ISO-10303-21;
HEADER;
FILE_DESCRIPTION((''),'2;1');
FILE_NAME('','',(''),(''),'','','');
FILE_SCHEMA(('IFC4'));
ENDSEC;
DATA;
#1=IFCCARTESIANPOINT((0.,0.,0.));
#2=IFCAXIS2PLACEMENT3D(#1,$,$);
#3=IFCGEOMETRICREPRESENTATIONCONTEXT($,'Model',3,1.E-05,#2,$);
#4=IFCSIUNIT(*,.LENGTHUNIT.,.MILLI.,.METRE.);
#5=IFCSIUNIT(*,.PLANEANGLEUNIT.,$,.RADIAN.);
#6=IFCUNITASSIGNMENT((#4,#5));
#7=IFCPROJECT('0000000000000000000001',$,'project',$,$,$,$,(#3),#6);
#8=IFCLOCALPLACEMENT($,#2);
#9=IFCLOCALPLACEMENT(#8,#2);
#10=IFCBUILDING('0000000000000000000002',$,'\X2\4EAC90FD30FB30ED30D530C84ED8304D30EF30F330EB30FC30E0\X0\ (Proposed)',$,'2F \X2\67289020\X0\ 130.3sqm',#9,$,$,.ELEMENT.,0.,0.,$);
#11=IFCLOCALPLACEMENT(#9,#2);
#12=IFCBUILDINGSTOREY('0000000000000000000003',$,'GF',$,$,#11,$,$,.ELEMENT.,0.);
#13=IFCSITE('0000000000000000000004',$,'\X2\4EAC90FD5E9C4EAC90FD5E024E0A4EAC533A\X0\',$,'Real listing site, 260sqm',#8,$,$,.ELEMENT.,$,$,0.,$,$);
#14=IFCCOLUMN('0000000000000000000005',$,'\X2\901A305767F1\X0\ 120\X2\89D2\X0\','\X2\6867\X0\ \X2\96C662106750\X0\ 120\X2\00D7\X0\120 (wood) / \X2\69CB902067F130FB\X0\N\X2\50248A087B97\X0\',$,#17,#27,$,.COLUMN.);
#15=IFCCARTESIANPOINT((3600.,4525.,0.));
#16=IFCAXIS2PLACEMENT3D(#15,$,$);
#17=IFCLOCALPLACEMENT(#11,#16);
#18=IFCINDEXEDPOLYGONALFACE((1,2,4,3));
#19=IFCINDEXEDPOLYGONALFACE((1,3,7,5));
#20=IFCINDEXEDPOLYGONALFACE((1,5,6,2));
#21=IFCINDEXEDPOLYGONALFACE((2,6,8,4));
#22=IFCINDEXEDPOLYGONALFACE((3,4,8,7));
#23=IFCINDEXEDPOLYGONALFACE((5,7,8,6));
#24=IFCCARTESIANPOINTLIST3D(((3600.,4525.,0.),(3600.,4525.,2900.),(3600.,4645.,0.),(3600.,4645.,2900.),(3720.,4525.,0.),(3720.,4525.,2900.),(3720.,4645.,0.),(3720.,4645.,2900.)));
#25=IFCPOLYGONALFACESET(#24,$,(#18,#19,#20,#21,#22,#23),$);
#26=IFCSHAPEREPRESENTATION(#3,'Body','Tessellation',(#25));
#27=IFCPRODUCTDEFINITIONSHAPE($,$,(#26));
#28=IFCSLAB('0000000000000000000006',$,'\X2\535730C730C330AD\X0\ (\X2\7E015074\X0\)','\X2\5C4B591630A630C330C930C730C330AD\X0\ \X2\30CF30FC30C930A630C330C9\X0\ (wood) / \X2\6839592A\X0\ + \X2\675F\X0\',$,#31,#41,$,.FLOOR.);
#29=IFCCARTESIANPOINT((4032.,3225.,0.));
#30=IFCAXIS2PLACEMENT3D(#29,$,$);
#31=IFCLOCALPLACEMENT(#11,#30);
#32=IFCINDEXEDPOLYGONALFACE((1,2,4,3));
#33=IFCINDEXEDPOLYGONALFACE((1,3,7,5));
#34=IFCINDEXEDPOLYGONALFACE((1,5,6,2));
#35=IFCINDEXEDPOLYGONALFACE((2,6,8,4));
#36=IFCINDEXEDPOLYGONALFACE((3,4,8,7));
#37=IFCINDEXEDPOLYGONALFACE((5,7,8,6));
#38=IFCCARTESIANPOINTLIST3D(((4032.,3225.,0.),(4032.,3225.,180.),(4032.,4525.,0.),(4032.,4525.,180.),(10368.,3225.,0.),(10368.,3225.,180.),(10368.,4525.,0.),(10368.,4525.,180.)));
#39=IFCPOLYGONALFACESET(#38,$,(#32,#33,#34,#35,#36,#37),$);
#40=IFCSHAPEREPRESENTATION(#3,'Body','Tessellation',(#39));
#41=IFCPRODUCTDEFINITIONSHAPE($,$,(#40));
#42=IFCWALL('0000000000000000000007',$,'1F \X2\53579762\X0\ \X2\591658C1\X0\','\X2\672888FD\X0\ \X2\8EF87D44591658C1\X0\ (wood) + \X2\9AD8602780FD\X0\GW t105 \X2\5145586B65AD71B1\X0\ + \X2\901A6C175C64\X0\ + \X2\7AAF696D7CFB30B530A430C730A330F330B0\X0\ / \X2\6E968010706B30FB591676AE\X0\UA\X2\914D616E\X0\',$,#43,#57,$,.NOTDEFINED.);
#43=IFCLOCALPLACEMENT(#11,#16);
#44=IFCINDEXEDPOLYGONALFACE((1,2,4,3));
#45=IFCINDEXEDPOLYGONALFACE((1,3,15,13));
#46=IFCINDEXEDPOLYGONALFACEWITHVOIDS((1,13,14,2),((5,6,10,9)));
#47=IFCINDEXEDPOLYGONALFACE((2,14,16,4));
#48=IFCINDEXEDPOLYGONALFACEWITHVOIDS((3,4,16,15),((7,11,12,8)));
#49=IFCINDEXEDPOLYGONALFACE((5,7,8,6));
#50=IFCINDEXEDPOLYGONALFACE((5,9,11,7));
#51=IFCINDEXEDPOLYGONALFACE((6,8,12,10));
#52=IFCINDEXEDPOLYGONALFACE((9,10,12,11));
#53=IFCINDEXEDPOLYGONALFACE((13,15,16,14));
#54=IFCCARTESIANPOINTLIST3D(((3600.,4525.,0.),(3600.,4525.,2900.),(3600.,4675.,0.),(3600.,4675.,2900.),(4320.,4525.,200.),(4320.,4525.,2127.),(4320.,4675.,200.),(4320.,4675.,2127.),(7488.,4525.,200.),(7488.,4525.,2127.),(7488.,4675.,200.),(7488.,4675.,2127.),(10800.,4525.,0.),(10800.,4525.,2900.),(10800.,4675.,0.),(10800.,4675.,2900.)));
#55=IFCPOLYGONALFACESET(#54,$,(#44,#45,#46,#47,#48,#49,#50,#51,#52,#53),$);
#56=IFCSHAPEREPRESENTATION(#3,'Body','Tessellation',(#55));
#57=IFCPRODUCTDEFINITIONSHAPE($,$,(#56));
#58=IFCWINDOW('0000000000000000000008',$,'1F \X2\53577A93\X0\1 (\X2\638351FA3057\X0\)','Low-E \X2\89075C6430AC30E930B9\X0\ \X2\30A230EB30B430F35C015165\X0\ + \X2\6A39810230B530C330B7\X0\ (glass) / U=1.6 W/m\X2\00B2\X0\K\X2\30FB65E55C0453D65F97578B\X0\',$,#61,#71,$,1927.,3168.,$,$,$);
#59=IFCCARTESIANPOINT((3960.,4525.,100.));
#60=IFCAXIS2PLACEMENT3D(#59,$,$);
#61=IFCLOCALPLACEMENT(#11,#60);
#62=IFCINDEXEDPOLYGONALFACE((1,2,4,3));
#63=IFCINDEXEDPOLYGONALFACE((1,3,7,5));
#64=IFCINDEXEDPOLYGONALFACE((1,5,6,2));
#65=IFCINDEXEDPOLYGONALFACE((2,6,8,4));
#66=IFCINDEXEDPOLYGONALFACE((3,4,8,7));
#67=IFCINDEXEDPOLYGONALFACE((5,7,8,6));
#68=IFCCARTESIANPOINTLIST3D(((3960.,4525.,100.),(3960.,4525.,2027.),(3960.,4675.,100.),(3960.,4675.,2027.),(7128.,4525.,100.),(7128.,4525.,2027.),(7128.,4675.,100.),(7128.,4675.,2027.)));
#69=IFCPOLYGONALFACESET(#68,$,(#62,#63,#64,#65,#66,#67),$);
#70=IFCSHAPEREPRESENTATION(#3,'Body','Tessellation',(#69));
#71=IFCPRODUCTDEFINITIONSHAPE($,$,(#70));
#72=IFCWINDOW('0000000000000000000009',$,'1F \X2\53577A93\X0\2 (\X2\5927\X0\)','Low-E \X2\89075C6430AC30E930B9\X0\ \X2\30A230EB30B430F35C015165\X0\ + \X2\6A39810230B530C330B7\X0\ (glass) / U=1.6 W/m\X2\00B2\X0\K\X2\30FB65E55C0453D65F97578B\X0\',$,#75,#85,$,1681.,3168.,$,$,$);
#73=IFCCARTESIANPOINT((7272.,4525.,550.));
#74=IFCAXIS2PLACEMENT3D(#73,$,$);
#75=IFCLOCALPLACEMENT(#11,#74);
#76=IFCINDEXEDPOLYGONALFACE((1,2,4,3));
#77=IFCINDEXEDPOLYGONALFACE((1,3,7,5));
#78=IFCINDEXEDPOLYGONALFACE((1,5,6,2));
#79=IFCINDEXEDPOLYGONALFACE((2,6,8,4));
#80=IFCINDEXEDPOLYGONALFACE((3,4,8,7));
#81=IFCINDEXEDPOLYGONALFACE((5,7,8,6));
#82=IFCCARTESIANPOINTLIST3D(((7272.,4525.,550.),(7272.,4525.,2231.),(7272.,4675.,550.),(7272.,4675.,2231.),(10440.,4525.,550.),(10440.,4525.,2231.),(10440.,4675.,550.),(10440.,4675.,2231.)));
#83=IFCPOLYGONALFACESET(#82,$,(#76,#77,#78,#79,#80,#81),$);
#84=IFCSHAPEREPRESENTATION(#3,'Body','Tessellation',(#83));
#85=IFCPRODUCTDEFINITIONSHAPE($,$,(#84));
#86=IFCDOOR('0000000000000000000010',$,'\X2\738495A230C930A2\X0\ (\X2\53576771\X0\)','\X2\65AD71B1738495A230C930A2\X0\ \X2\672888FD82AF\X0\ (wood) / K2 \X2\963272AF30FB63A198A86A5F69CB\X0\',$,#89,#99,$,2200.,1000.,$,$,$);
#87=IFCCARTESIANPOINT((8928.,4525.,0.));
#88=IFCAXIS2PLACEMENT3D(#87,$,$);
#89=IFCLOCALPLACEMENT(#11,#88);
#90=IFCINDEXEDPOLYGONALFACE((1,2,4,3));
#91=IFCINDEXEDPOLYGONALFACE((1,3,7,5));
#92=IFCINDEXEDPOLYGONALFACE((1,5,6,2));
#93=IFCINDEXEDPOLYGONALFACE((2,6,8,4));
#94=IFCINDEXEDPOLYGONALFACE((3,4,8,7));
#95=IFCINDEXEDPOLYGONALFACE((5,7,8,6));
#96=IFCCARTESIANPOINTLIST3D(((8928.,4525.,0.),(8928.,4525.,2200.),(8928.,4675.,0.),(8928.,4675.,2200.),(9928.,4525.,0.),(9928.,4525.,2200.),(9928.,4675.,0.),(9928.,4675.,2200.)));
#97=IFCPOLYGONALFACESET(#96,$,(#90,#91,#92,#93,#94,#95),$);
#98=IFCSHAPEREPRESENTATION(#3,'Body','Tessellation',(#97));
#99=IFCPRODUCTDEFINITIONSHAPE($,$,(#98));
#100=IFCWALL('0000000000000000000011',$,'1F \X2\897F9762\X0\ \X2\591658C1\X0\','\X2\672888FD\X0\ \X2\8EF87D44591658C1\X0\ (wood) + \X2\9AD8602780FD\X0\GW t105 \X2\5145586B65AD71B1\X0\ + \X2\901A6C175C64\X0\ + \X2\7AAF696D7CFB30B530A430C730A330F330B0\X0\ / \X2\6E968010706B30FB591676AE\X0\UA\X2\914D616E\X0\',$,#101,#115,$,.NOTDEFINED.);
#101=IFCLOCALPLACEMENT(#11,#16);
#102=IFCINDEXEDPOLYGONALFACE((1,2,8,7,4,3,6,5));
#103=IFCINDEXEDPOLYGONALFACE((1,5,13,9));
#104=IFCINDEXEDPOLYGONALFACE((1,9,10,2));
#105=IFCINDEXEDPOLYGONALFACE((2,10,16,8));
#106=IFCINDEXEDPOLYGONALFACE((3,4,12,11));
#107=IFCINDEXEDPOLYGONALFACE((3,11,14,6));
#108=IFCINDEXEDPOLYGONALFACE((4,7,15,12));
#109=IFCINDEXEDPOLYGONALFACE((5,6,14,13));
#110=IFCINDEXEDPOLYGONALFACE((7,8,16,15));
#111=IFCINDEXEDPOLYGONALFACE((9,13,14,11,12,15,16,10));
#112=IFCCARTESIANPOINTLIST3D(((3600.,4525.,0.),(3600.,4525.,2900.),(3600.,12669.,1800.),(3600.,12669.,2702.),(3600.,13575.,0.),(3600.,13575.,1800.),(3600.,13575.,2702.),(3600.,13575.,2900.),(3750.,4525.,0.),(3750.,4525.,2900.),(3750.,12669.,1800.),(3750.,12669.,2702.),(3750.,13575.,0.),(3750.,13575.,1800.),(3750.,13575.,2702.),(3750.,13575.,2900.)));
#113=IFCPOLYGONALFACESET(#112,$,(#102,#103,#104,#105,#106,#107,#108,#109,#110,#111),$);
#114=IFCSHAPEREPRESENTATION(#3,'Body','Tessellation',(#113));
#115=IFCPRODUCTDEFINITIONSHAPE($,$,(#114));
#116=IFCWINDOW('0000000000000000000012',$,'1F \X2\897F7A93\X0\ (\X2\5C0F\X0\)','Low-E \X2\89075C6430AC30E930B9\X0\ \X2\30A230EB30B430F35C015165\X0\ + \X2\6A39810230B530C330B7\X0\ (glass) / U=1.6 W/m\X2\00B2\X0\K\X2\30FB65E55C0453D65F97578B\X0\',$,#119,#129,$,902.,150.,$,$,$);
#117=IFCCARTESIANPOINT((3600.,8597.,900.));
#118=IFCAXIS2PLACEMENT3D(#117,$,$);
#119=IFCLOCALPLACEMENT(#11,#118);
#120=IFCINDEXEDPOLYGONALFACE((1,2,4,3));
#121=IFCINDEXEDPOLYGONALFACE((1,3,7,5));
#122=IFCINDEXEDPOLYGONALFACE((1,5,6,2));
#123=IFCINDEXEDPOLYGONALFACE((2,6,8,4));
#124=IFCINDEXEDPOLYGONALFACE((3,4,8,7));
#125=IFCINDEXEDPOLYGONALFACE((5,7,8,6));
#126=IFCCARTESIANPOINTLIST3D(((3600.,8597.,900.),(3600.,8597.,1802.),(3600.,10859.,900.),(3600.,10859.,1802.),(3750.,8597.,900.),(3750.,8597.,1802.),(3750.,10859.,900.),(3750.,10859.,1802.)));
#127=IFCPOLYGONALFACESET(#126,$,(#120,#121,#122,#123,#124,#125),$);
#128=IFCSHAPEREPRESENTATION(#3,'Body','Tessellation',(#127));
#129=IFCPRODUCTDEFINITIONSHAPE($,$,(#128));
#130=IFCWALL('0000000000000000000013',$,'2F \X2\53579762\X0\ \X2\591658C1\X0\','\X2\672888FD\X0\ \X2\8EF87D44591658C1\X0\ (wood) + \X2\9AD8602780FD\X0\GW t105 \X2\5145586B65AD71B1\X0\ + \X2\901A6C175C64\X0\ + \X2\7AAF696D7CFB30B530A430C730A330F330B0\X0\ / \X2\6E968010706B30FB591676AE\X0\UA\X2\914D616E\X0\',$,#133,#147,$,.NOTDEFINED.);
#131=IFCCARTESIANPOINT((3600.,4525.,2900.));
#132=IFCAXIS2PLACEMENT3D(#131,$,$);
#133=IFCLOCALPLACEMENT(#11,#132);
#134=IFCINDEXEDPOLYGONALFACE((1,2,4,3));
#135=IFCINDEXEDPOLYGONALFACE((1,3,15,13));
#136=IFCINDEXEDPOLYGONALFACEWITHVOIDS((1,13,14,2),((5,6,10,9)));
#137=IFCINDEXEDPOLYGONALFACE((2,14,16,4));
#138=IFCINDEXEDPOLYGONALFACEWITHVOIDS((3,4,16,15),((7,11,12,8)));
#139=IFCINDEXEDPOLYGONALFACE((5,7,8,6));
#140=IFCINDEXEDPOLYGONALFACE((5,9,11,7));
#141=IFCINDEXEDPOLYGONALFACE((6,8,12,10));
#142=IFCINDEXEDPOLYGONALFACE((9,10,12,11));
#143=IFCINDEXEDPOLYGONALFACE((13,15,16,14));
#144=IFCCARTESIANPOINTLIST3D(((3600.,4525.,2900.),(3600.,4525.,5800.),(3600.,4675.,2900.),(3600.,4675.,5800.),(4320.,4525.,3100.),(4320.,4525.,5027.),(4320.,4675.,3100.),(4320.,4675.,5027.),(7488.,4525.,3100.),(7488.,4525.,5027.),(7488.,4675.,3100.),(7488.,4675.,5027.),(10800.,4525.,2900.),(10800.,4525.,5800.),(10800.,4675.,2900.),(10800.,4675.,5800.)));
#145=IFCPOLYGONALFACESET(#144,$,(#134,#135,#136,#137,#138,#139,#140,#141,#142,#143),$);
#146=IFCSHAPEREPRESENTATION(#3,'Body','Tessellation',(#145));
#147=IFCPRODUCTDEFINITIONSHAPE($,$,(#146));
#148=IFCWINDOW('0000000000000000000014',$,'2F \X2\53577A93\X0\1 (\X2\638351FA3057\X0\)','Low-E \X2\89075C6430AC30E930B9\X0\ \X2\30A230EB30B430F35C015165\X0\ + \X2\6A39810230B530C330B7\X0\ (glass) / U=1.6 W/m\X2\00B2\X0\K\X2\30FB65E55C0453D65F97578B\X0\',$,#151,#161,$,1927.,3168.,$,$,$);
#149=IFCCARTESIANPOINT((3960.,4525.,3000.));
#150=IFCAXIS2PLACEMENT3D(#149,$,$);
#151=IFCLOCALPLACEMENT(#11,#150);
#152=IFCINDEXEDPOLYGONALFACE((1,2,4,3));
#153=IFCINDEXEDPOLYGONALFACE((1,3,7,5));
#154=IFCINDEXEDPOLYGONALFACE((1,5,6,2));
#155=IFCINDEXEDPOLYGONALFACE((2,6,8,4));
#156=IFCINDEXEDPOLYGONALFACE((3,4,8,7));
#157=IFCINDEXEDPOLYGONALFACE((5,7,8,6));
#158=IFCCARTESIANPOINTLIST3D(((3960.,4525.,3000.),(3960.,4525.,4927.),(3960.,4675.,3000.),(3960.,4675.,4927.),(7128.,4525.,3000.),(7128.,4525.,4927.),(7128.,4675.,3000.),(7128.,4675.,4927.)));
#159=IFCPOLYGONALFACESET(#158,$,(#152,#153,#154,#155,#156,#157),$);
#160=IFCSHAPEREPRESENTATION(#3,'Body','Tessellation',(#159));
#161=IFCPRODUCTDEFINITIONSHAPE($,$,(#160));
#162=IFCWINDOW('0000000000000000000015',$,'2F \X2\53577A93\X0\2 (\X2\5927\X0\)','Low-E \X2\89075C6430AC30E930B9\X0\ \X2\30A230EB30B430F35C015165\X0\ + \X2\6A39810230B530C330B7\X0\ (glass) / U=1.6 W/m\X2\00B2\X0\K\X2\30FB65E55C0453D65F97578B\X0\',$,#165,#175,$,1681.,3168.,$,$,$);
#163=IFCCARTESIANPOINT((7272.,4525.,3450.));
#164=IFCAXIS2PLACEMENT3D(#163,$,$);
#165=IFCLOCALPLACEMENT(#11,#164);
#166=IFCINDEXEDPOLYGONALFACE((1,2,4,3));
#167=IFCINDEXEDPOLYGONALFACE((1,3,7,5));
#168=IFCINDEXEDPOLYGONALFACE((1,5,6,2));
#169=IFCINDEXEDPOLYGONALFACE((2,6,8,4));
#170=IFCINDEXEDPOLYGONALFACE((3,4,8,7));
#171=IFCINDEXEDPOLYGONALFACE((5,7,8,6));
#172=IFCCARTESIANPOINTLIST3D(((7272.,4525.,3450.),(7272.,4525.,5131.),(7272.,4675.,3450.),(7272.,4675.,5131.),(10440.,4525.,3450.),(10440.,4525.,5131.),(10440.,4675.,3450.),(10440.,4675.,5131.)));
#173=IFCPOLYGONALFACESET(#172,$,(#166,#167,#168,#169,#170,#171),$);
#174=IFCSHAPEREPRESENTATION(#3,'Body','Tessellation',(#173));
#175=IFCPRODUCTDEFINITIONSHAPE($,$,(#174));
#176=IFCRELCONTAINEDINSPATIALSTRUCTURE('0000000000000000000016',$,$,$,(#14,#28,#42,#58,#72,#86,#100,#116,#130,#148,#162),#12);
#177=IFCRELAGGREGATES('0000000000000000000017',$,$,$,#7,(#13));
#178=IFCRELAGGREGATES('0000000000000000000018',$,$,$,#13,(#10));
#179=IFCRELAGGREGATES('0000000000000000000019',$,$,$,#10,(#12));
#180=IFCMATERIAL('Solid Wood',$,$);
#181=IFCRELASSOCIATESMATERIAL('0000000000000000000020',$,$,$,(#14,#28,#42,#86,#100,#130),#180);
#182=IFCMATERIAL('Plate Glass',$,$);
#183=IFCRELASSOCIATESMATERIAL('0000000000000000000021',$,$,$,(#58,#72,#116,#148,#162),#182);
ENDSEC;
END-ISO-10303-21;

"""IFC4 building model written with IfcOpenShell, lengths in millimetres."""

from ifc_helpers import new_model, si_unit, frame, frame_2d, origin, place, context, project, spatial, rectangle, extrude, material, element, fill, save


model = new_model("IFC4")

# Units and contexts
model_context = context("Model", 3, precision=1e-05, world=origin())
ifc_project = project(units=[si_unit("LENGTHUNIT", "METRE", prefix="MILLI"), si_unit("PLANEANGLEUNIT", "RADIAN")], contexts=[model_context])

# Site, building, storey
site_placement = place(None, origin())
site = spatial("IfcSite", under=ifc_project, at=site_placement, Name="京都府京都市上京区", ObjectType="Real listing site, 260sqm", CompositionType="ELEMENT", RefElevation=0.0)
building_placement = place(site_placement, origin())
building = spatial("IfcBuilding", under=site, at=building_placement, Name="京都・ロフト付きワンルーム (Proposed)", ObjectType="2F 木造 130.3sqm", CompositionType="ELEMENT", ElevationOfRefHeight=0.0, ElevationOfTerrain=0.0)
storey_placement = place(building_placement, origin())
storey = spatial("IfcBuildingStorey", under=building, at=storey_placement, Name="GF", CompositionType="ELEMENT", Elevation=0.0)

# Column
ifc_material_1 = material(Name="Solid Wood")
column_placement = place(storey_placement, frame((3600.0, 4525.0, 0.0)))
element("IfcColumn", 1, at=column_placement, inside=storey, material=ifc_material_1, Name="通し柱 120角", Description="桧 集成材 120×120 (wood) / 構造柱・N値計算", PredefinedType="COLUMN", context=model_context, shape_type="SweptSolid", body=[
    extrude(rectangle(XDim=120.0, YDim=120.0, at=frame_2d((60.0, 60.0))), frame((3600.0, 4525.0, 0.0)), (0.0, 0.0, 1.0), 2900.0),
])

# Slab
slab_1_placement = place(storey_placement, frame((4032.0, 3225.0, 0.0)))
element("IfcSlab", 2, at=slab_1_placement, inside=storey, material=ifc_material_1, Name="南デッキ (縁側)", Description="屋外ウッドデッキ ハードウッド (wood) / 根太 + 束", PredefinedType="FLOOR", context=model_context, shape_type="SweptSolid", body=[
    extrude(rectangle(XDim=6336.0, YDim=1300.0, at=frame_2d((3168.0, 650.0))), frame((4032.0, 3225.0, 0.0)), (0.0, 0.0, 1.0), 180.0),
])

# Wall, openings, windows, door
wall_1_placement = place(storey_placement, frame((3600.0, 4525.0, 0.0)))
wall_1 = element("IfcWall", 3, at=wall_1_placement, inside=storey, material=ifc_material_1, Name="1F 南面 外壁", Description="木製 軸組外壁 (wood) + 高性能GW t105 充填断熱 + 通気層 + 窯業系サイディング / 準耐火・外皮UA配慮", PredefinedType="NOTDEFINED", context=model_context, shape_type="SweptSolid", body=[
    extrude(rectangle(XDim=7200.0, YDim=150.0, at=frame_2d((3600.0, 75.0))), frame((3600.0, 4525.0, 0.0)), (0.0, 0.0, 1.0), 2900.0),
])
opening_1_placement = place(storey_placement, frame((3960.0, 4525.0, 100.0)))
opening_1 = element("IfcOpeningElement", 4, at=opening_1_placement, cuts=wall_1, PredefinedType="NOTDEFINED", context=model_context, shape_type="SweptSolid", body=[
    extrude(rectangle(XDim=3168.0, YDim=150.0, at=frame_2d((1584.0, 75.0))), frame((3960.0, 4525.0, 100.0)), (0.0, 0.0, 1.0), 1927.0),
])
opening_2_placement = place(storey_placement, frame((7272.0, 4525.0, 550.0)))
opening_2 = element("IfcOpeningElement", 5, at=opening_2_placement, cuts=wall_1, PredefinedType="NOTDEFINED", context=model_context, shape_type="SweptSolid", body=[
    extrude(rectangle(XDim=3168.0, YDim=150.0, at=frame_2d((1584.0, 75.0))), frame((7272.0, 4525.0, 550.0)), (0.0, 0.0, 1.0), 1681.0),
])
opening_3_placement = place(storey_placement, frame((8928.0, 4525.0, 0.0)))
opening_3 = element("IfcOpeningElement", 6, at=opening_3_placement, cuts=wall_1, PredefinedType="NOTDEFINED", context=model_context, shape_type="SweptSolid", body=[
    extrude(rectangle(XDim=1000.0, YDim=150.0, at=frame_2d((500.0, 75.0))), frame((8928.0, 4525.0, 0.0)), (0.0, 0.0, 1.0), 2200.0),
])
ifc_material_2 = material(Name="Plate Glass")
window_1_placement = place(storey_placement, frame((3960.0, 4525.0, 100.0)))
window_1 = element("IfcWindow", 7, at=window_1_placement, inside=storey, material=ifc_material_2, Name="1F 南窓1 (掃出し)", Description="Low-E 複層ガラス アルゴン封入 + 樹脂サッシ (glass) / U=1.6 W/m²K・日射取得型", OverallHeight=1927.0, OverallWidth=3168.0, context=model_context, shape_type="SweptSolid", body=[
    extrude(rectangle(XDim=3168.0, YDim=150.0, at=frame_2d((1584.0, 75.0))), frame((3960.0, 4525.0, 100.0)), (0.0, 0.0, 1.0), 1927.0),
])
fill(opening_1, window_1)
window_2_placement = place(storey_placement, frame((7272.0, 4525.0, 550.0)))
window_2 = element("IfcWindow", 8, at=window_2_placement, inside=storey, material=ifc_material_2, Name="1F 南窓2 (大)", Description="Low-E 複層ガラス アルゴン封入 + 樹脂サッシ (glass) / U=1.6 W/m²K・日射取得型", OverallHeight=1681.0, OverallWidth=3168.0, context=model_context, shape_type="SweptSolid", body=[
    extrude(rectangle(XDim=3168.0, YDim=150.0, at=frame_2d((1584.0, 75.0))), frame((7272.0, 4525.0, 550.0)), (0.0, 0.0, 1.0), 1681.0),
])
fill(opening_2, window_2)
door_placement = place(storey_placement, frame((8928.0, 4525.0, 0.0)))
door = element("IfcDoor", 9, at=door_placement, inside=storey, material=ifc_material_1, Name="玄関ドア (南東)", Description="断熱玄関ドア 木製芯 (wood) / K2 防犯・採風機構", OverallHeight=2200.0, OverallWidth=1000.0, context=model_context, shape_type="SweptSolid", body=[
    extrude(rectangle(XDim=1000.0, YDim=150.0, at=frame_2d((500.0, 75.0))), frame((8928.0, 4525.0, 0.0)), (0.0, 0.0, 1.0), 2200.0),
])
fill(opening_3, door)

# Wall, opening, window
wall_2_placement = place(storey_placement, frame((3600.0, 4525.0, 0.0)))
wall_2 = element("IfcWall", 10, at=wall_2_placement, inside=storey, material=ifc_material_1, Name="1F 西面 外壁", Description="木製 軸組外壁 (wood) + 高性能GW t105 充填断熱 + 通気層 + 窯業系サイディング / 準耐火・外皮UA配慮", PredefinedType="NOTDEFINED", context=model_context, shape_type="SweptSolid", body=[
    extrude(rectangle(XDim=150.0, YDim=9050.0, at=frame_2d((75.0, 4525.0))), frame((3600.0, 4525.0, 0.0)), (0.0, 0.0, 1.0), 2900.0),
])
opening_4_placement = place(storey_placement, frame((3600.0, 8597.0, 900.0)))
opening_4 = element("IfcOpeningElement", 11, at=opening_4_placement, cuts=wall_2, PredefinedType="NOTDEFINED", context=model_context, shape_type="SweptSolid", body=[
    extrude(rectangle(XDim=150.0, YDim=2262.0, at=frame_2d((75.0, 1131.0))), frame((3600.0, 8597.0, 900.0)), (0.0, 0.0, 1.0), 902.0),
])
window_3_placement = place(storey_placement, frame((3600.0, 8597.0, 900.0)))
window_3 = element("IfcWindow", 12, at=window_3_placement, inside=storey, material=ifc_material_2, Name="1F 西窓 (小)", Description="Low-E 複層ガラス アルゴン封入 + 樹脂サッシ (glass) / U=1.6 W/m²K・日射取得型", OverallHeight=902.0, OverallWidth=150.0, context=model_context, shape_type="SweptSolid", body=[
    extrude(rectangle(XDim=150.0, YDim=2262.0, at=frame_2d((75.0, 1131.0))), frame((3600.0, 8597.0, 900.0)), (0.0, 0.0, 1.0), 902.0),
])
fill(opening_4, window_3)

# Wall, openings, windows
wall_3_placement = place(storey_placement, frame((3600.0, 4525.0, 2900.0)))
wall_3 = element("IfcWall", 13, at=wall_3_placement, inside=storey, material=ifc_material_1, Name="2F 南面 外壁", Description="木製 軸組外壁 (wood) + 高性能GW t105 充填断熱 + 通気層 + 窯業系サイディング / 準耐火・外皮UA配慮", PredefinedType="NOTDEFINED", context=model_context, shape_type="SweptSolid", body=[
    extrude(rectangle(XDim=7200.0, YDim=150.0, at=frame_2d((3600.0, 75.0))), frame((3600.0, 4525.0, 2900.0)), (0.0, 0.0, 1.0), 2900.0),
])
opening_5_placement = place(storey_placement, frame((3960.0, 4525.0, 3000.0)))
opening_5 = element("IfcOpeningElement", 14, at=opening_5_placement, cuts=wall_3, PredefinedType="NOTDEFINED", context=model_context, shape_type="SweptSolid", body=[
    extrude(rectangle(XDim=3168.0, YDim=150.0, at=frame_2d((1584.0, 75.0))), frame((3960.0, 4525.0, 3000.0)), (0.0, 0.0, 1.0), 1927.0),
])
opening_6_placement = place(storey_placement, frame((7272.0, 4525.0, 3450.0)))
opening_6 = element("IfcOpeningElement", 15, at=opening_6_placement, cuts=wall_3, PredefinedType="NOTDEFINED", context=model_context, shape_type="SweptSolid", body=[
    extrude(rectangle(XDim=3168.0, YDim=150.0, at=frame_2d((1584.0, 75.0))), frame((7272.0, 4525.0, 3450.0)), (0.0, 0.0, 1.0), 1681.0),
])
window_4_placement = place(storey_placement, frame((3960.0, 4525.0, 3000.0)))
window_4 = element("IfcWindow", 16, at=window_4_placement, inside=storey, material=ifc_material_2, Name="2F 南窓1 (掃出し)", Description="Low-E 複層ガラス アルゴン封入 + 樹脂サッシ (glass) / U=1.6 W/m²K・日射取得型", OverallHeight=1927.0, OverallWidth=3168.0, context=model_context, shape_type="SweptSolid", body=[
    extrude(rectangle(XDim=3168.0, YDim=150.0, at=frame_2d((1584.0, 75.0))), frame((3960.0, 4525.0, 3000.0)), (0.0, 0.0, 1.0), 1927.0),
])
fill(opening_5, window_4)
window_5_placement = place(storey_placement, frame((7272.0, 4525.0, 3450.0)))
window_5 = element("IfcWindow", 17, at=window_5_placement, inside=storey, material=ifc_material_2, Name="2F 南窓2 (大)", Description="Low-E 複層ガラス アルゴン封入 + 樹脂サッシ (glass) / U=1.6 W/m²K・日射取得型", OverallHeight=1681.0, OverallWidth=3168.0, context=model_context, shape_type="SweptSolid", body=[
    extrude(rectangle(XDim=3168.0, YDim=150.0, at=frame_2d((1584.0, 75.0))), frame((7272.0, 4525.0, 3450.0)), (0.0, 0.0, 1.0), 1681.0),
])
fill(opening_6, window_5)

save(model, "model.ifc")
